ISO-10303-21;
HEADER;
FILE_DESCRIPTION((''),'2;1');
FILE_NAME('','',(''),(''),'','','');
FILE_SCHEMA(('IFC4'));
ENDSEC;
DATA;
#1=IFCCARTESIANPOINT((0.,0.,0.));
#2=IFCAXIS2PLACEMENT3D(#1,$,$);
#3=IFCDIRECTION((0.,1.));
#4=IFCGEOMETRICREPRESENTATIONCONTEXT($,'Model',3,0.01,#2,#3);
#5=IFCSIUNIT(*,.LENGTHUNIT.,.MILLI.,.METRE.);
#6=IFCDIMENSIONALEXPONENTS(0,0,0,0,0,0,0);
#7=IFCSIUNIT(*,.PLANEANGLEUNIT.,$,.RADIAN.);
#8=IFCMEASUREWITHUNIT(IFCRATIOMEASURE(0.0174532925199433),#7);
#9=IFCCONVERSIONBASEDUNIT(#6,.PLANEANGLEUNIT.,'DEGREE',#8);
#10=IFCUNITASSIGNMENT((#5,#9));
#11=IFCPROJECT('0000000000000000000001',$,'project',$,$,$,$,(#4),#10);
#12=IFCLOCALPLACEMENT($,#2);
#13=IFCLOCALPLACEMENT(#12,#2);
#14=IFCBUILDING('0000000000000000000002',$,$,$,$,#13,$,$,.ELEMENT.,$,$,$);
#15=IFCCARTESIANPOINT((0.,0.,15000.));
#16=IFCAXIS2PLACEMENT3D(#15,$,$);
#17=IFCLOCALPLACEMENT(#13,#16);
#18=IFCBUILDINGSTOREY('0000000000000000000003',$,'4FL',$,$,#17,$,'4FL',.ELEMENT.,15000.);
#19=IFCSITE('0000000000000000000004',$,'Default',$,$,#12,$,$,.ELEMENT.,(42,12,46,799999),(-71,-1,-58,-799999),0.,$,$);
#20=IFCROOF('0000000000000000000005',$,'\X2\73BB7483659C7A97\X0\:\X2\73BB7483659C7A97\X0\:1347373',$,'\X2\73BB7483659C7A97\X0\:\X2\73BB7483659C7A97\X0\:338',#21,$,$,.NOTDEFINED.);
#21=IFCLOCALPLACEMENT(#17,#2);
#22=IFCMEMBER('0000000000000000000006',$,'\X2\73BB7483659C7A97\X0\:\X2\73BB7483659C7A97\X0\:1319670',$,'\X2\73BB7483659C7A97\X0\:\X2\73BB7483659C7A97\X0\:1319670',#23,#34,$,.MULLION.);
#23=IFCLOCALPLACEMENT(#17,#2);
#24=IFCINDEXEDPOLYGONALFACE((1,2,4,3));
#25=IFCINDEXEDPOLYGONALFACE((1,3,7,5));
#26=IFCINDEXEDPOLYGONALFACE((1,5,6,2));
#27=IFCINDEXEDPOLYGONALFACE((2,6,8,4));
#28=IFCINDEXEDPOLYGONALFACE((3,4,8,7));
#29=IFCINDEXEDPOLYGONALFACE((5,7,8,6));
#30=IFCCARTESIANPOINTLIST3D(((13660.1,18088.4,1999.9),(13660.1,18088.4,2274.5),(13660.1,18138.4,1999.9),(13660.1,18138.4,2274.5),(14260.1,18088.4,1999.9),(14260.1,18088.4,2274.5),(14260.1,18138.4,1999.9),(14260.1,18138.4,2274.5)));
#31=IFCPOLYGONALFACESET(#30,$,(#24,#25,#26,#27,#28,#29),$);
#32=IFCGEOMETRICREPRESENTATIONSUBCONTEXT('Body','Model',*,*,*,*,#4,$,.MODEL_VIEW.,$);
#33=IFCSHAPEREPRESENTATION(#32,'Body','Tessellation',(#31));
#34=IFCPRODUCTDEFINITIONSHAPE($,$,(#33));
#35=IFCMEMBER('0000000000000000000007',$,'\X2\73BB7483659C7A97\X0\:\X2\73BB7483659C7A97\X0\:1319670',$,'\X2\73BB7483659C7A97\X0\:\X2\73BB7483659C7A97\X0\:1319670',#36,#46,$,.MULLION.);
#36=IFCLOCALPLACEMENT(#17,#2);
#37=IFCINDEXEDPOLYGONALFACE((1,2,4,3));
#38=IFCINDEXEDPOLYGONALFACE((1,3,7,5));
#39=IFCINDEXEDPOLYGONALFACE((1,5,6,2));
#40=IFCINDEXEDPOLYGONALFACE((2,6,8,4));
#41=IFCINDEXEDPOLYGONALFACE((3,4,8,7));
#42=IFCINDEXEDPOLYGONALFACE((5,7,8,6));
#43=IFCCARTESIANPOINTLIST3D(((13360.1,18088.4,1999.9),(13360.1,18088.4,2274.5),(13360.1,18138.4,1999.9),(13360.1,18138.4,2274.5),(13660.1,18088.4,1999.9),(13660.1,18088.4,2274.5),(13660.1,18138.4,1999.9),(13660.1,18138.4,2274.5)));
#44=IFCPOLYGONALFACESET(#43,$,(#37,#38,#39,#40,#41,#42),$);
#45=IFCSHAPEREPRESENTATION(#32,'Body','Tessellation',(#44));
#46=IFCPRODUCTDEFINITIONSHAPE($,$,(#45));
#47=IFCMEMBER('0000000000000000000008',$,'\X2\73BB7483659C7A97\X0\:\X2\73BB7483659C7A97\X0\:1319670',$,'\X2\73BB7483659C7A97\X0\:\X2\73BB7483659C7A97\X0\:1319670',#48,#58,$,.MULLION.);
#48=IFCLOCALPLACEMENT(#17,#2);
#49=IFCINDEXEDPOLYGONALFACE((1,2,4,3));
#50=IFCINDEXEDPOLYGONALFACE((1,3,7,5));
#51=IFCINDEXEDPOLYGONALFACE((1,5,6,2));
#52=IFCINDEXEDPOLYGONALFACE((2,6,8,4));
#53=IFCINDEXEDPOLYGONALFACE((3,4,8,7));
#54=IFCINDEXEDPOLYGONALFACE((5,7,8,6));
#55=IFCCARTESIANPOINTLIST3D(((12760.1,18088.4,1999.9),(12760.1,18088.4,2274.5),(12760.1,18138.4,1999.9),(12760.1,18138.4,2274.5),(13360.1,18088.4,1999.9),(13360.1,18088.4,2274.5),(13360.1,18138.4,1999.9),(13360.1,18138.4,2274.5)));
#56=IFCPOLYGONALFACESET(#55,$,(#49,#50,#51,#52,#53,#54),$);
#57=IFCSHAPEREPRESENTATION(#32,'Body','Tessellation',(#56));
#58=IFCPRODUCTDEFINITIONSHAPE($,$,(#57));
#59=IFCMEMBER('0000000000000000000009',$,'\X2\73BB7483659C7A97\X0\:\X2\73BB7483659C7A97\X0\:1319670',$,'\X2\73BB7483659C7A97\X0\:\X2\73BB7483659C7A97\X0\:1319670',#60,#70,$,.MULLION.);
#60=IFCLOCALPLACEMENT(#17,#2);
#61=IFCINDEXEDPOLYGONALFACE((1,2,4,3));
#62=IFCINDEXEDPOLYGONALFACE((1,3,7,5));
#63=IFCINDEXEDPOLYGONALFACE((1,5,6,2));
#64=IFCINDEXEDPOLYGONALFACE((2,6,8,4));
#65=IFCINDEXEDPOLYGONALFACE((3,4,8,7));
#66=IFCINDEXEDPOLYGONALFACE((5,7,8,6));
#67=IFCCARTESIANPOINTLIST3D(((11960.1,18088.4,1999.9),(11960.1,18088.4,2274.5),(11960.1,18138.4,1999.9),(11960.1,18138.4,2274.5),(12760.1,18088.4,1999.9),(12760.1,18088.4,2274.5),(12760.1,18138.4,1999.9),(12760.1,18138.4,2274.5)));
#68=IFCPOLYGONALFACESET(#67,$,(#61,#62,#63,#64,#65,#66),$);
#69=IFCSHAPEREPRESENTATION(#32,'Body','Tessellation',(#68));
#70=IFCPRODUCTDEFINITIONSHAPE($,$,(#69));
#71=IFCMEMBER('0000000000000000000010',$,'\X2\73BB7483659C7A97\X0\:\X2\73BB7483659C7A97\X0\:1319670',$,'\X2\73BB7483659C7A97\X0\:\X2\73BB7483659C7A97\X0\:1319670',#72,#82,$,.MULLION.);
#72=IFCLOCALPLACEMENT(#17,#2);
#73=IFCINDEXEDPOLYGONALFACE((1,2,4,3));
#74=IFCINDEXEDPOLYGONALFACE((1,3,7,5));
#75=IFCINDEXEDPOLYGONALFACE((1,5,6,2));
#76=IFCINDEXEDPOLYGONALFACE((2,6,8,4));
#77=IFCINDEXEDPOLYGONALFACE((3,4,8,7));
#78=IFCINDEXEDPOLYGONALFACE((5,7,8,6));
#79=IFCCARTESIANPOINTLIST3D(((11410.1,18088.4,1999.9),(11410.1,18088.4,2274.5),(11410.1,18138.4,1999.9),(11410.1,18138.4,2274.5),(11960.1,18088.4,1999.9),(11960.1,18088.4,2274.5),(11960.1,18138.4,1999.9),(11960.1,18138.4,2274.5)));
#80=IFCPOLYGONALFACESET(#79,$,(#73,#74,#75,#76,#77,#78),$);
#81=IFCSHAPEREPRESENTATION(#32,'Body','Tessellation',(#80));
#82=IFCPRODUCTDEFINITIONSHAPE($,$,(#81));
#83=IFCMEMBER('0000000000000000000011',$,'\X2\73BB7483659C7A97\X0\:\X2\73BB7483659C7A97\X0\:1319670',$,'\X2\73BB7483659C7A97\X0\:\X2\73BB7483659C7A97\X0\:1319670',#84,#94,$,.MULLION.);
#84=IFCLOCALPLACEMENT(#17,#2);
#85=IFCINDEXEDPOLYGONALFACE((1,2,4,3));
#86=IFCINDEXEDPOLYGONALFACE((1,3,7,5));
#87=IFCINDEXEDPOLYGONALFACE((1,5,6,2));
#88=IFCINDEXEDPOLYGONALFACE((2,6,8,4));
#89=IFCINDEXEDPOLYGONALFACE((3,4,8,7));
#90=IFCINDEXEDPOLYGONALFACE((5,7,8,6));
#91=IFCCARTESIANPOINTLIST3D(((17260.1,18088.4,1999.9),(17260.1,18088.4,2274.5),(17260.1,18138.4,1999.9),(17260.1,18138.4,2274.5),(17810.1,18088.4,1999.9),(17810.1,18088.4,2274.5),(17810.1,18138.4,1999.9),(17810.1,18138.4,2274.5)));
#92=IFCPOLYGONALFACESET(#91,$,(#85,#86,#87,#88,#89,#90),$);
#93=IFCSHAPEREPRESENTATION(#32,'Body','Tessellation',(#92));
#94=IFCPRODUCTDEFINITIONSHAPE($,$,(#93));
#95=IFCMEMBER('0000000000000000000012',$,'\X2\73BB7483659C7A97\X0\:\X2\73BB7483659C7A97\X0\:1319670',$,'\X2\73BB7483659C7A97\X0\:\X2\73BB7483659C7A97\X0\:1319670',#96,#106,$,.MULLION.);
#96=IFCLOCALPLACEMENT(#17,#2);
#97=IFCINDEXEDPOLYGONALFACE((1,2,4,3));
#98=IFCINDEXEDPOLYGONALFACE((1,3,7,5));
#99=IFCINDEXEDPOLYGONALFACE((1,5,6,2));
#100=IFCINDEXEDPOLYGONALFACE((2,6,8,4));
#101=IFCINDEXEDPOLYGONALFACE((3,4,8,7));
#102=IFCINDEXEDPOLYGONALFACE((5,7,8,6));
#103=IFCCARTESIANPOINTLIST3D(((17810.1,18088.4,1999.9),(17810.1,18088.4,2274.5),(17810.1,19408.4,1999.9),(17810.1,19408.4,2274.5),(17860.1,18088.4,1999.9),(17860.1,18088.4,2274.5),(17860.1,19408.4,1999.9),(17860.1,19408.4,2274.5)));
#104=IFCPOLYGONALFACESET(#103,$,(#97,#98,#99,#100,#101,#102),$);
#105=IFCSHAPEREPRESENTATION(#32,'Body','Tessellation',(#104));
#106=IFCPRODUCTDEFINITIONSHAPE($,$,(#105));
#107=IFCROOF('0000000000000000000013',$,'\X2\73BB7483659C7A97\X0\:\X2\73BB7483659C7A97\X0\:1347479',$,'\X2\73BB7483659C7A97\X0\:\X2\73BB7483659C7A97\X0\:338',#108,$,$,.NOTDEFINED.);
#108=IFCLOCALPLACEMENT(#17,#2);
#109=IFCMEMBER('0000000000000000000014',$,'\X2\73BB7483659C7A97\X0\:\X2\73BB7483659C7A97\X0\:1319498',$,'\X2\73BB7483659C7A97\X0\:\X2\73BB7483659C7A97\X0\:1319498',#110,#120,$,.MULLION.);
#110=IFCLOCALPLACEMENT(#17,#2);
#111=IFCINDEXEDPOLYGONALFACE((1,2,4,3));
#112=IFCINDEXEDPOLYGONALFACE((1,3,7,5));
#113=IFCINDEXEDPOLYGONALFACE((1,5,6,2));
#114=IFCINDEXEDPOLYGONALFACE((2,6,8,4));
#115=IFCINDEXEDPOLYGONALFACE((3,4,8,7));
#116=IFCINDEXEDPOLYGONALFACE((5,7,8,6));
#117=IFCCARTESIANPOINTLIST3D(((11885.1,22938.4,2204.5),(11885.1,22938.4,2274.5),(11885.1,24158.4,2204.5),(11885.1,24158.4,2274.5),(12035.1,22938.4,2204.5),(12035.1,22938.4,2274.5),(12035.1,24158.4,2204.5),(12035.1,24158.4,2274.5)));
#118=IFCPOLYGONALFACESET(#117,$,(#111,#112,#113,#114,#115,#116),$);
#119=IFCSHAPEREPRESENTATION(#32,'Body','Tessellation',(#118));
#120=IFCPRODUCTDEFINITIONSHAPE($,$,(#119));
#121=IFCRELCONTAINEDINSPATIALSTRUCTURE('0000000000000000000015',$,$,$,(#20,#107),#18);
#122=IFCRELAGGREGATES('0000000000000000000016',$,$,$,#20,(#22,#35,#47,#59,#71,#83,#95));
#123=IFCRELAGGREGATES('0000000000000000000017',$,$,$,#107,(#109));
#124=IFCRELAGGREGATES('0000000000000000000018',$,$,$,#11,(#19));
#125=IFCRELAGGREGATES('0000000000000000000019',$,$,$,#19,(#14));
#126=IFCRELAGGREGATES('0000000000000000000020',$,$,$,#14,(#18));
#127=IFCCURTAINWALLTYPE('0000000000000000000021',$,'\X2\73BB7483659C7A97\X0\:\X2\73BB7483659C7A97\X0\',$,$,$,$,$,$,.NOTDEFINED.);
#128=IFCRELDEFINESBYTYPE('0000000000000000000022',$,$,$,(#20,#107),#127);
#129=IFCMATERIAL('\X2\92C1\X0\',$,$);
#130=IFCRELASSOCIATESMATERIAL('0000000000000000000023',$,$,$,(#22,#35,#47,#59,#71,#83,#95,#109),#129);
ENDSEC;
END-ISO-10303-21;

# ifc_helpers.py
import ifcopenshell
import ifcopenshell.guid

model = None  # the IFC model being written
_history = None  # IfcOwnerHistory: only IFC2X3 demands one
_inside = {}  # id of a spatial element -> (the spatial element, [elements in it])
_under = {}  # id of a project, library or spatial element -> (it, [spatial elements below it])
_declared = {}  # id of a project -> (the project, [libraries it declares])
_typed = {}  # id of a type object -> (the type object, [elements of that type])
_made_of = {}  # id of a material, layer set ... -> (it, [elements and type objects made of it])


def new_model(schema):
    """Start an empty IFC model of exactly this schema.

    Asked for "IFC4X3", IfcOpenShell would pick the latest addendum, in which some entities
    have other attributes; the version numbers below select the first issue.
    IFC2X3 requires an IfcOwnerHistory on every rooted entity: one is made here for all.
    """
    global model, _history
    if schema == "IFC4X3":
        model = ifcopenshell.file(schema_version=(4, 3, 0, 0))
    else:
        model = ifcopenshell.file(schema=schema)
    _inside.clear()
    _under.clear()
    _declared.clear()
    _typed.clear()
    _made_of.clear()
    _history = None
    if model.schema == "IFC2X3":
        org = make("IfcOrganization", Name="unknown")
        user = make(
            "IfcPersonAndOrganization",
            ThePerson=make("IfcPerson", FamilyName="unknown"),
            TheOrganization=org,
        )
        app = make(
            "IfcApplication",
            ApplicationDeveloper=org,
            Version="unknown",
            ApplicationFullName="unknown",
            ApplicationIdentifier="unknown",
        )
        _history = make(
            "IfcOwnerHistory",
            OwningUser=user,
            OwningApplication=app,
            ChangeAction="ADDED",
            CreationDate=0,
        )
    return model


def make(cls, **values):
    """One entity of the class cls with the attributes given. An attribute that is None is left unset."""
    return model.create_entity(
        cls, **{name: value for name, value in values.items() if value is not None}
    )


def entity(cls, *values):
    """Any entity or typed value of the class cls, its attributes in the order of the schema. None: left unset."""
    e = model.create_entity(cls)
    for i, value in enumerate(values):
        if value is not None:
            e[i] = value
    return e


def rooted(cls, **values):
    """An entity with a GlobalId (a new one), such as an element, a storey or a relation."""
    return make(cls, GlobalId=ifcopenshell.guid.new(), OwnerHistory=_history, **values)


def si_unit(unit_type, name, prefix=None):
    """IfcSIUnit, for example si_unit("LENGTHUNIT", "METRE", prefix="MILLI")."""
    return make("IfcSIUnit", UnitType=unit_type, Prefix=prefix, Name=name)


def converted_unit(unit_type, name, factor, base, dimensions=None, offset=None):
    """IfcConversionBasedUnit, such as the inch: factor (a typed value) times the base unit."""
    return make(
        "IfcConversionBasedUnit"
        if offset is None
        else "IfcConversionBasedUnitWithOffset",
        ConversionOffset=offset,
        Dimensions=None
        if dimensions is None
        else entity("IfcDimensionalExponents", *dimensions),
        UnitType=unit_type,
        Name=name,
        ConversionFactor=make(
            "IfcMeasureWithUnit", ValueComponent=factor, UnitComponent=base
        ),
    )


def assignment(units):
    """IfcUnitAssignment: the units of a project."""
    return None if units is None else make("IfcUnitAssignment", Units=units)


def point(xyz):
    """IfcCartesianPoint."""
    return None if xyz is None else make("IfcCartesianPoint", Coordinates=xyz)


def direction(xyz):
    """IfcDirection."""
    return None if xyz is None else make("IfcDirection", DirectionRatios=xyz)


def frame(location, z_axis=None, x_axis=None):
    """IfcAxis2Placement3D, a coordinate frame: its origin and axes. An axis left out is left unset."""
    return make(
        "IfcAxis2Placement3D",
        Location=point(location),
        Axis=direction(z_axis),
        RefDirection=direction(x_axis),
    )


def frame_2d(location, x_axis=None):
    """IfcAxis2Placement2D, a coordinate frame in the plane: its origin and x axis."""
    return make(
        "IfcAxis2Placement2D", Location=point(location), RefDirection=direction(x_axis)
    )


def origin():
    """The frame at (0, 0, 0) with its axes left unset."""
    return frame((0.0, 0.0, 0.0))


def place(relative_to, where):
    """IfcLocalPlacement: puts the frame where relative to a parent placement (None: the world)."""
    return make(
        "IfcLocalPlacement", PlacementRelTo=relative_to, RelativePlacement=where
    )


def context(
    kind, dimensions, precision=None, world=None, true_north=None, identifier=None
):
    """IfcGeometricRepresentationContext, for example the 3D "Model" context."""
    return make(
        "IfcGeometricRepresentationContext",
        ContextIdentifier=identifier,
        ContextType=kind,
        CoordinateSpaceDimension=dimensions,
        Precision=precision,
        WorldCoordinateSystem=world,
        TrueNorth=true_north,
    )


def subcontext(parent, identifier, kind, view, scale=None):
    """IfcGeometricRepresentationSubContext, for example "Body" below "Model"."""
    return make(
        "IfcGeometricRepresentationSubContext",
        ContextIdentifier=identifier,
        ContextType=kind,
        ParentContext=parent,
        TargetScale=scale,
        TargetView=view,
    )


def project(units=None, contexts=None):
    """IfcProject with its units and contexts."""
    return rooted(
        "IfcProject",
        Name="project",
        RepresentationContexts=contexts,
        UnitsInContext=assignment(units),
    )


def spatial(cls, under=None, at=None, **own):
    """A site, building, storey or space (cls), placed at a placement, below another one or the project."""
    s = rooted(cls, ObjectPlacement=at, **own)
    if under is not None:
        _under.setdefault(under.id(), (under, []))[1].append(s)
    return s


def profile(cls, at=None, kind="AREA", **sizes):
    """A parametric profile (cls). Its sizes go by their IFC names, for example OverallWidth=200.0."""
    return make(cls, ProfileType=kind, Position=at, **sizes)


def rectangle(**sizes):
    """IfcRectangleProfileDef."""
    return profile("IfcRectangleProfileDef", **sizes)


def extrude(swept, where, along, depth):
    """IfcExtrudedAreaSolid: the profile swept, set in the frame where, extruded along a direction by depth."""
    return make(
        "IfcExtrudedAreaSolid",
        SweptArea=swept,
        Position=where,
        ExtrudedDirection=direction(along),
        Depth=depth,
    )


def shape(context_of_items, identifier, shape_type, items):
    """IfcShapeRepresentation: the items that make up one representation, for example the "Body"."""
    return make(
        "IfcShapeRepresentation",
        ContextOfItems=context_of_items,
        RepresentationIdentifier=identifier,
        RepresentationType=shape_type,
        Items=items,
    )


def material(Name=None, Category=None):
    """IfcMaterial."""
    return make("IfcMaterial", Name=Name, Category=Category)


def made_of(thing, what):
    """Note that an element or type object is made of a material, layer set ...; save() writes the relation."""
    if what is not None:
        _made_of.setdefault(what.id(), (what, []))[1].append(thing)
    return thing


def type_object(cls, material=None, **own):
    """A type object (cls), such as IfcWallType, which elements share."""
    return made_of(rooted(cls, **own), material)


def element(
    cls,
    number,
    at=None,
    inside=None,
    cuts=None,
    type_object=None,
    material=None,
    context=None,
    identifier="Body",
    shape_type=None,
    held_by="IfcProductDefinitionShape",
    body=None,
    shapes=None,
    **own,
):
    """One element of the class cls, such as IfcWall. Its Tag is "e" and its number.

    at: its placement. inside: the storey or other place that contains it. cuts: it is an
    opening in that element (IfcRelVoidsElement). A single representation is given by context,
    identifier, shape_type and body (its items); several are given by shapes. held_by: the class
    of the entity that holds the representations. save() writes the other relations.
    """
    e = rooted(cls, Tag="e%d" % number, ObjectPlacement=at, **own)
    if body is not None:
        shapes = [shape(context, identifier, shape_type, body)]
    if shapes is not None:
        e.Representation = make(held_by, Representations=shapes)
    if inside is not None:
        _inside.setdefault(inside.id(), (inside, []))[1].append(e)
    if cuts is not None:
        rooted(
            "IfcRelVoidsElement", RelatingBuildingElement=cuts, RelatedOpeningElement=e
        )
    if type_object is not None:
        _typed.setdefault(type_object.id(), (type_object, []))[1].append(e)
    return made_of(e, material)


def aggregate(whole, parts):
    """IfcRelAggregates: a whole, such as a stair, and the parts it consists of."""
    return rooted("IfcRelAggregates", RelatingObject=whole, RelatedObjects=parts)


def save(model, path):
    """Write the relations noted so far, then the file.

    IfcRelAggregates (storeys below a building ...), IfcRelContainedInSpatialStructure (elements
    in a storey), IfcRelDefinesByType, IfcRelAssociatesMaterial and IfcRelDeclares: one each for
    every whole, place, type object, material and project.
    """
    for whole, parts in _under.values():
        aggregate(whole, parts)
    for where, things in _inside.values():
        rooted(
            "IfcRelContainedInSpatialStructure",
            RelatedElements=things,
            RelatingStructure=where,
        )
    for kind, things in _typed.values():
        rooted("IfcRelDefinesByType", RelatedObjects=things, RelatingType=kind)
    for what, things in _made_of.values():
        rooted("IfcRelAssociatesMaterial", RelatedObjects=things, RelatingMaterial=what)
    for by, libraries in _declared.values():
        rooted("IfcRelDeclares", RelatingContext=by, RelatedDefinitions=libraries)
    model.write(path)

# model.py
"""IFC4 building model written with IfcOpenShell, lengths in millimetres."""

from ifc_helpers import new_model, entity, si_unit, converted_unit, direction, frame, frame_2d, origin, place, context, subcontext, project, spatial, rectangle, extrude, material, type_object, element, aggregate, save


model = new_model("IFC4")

# Units and contexts
model_context = context("Model", 3, precision=0.01, world=origin(), true_north=direction((0.0, 1.0)))
body_context = subcontext(model_context, "Body", "Model", "MODEL_VIEW")
ifc_project = project(units=[si_unit("LENGTHUNIT", "METRE", prefix="MILLI"), converted_unit("PLANEANGLEUNIT", "DEGREE", entity("IfcRatioMeasure", 0.0174532925199433), si_unit("PLANEANGLEUNIT", "RADIAN"), dimensions=[0, 0, 0, 0, 0, 0, 0])], contexts=[model_context])

# Site, building, storey
site_placement = place(None, origin())
site = spatial("IfcSite", under=ifc_project, at=site_placement, Name="Default", CompositionType="ELEMENT", RefLatitude=(42, 12, 46, 799999), RefLongitude=(-71, -1, -58, -799999), RefElevation=0.0)
building_placement = place(site_placement, origin())
building = spatial("IfcBuilding", under=site, at=building_placement, CompositionType="ELEMENT")
storey_placement = place(building_placement, frame((0.0, 0.0, 15000.0)))
storey = spatial("IfcBuildingStorey", under=building, at=storey_placement, Name="4FL", LongName="4FL", CompositionType="ELEMENT", Elevation=15000.0)

# Roof, members
curtain_wall_type = type_object("IfcCurtainWallType", Name="玻璃斜窗:玻璃斜窗", PredefinedType="NOTDEFINED")
roof_1_placement = place(storey_placement, frame((0.0, 0.0, -15000.0)))
roof_1 = element("IfcRoof", 1, at=roof_1_placement, inside=storey, type_object=curtain_wall_type, Name="玻璃斜窗:玻璃斜窗:1347373", ObjectType="玻璃斜窗:玻璃斜窗:338", PredefinedType="NOTDEFINED")
ifc_material = material(Name="鋁")
member_1_placement = place(roof_1_placement, frame((0.0, 0.0, 15000.0)))
member_1 = element("IfcMember", 2, at=member_1_placement, material=ifc_material, Name="玻璃斜窗:玻璃斜窗:1319670", ObjectType="玻璃斜窗:玻璃斜窗:1319670", PredefinedType="MULLION", context=body_context, shape_type="SweptSolid", body=[
    extrude(rectangle(XDim=274.5, YDim=50.0, at=frame_2d((0.0, 0.0), x_axis=(1.0, 0.0))), frame((14260.1, 18113.4, 2137.2), z_axis=(-1.0, 0.0, 0.0), x_axis=(0.0, 0.0, -1.0)), (0.0, 0.0, 1.0), 600.0),
])
member_2_placement = place(roof_1_placement, frame((0.0, 0.0, 15000.0)))
member_2 = element("IfcMember", 3, at=member_2_placement, material=ifc_material, Name="玻璃斜窗:玻璃斜窗:1319670", ObjectType="玻璃斜窗:玻璃斜窗:1319670", PredefinedType="MULLION", context=body_context, shape_type="SweptSolid", body=[
    extrude(rectangle(XDim=274.5, YDim=50.0, at=frame_2d((0.0, 0.0), x_axis=(1.0, 0.0))), frame((13660.1, 18113.4, 2137.2), z_axis=(-1.0, 0.0, 0.0), x_axis=(0.0, 0.0, -1.0)), (0.0, 0.0, 1.0), 300.0),
])
member_3_placement = place(roof_1_placement, frame((0.0, 0.0, 15000.0)))
member_3 = element("IfcMember", 4, at=member_3_placement, material=ifc_material, Name="玻璃斜窗:玻璃斜窗:1319670", ObjectType="玻璃斜窗:玻璃斜窗:1319670", PredefinedType="MULLION", context=body_context, shape_type="SweptSolid", body=[
    extrude(rectangle(XDim=274.5, YDim=50.0, at=frame_2d((0.0, 0.0), x_axis=(1.0, 0.0))), frame((13360.1, 18113.4, 2137.2), z_axis=(-1.0, 0.0, 0.0), x_axis=(0.0, 0.0, -1.0)), (0.0, 0.0, 1.0), 600.0),
])
member_4_placement = place(roof_1_placement, frame((0.0, 0.0, 15000.0)))
member_4 = element("IfcMember", 5, at=member_4_placement, material=ifc_material, Name="玻璃斜窗:玻璃斜窗:1319670", ObjectType="玻璃斜窗:玻璃斜窗:1319670", PredefinedType="MULLION", context=body_context, shape_type="SweptSolid", body=[
    extrude(rectangle(XDim=274.5, YDim=50.0, at=frame_2d((0.0, 0.0), x_axis=(1.0, 0.0))), frame((12760.1, 18113.4, 2137.2), z_axis=(-1.0, 0.0, 0.0), x_axis=(0.0, 0.0, -1.0)), (0.0, 0.0, 1.0), 800.0),
])
member_5_placement = place(roof_1_placement, frame((0.0, 0.0, 15000.0)))
member_5 = element("IfcMember", 6, at=member_5_placement, material=ifc_material, Name="玻璃斜窗:玻璃斜窗:1319670", ObjectType="玻璃斜窗:玻璃斜窗:1319670", PredefinedType="MULLION", context=body_context, shape_type="SweptSolid", body=[
    extrude(rectangle(XDim=274.5, YDim=50.0, at=frame_2d((0.0, 0.0), x_axis=(1.0, 0.0))), frame((11960.1, 18113.4, 2137.2), z_axis=(-1.0, 0.0, 0.0), x_axis=(0.0, 0.0, -1.0)), (0.0, 0.0, 1.0), 550.0),
])
member_6_placement = place(roof_1_placement, frame((0.0, 0.0, 15000.0)))
member_6 = element("IfcMember", 7, at=member_6_placement, material=ifc_material, Name="玻璃斜窗:玻璃斜窗:1319670", ObjectType="玻璃斜窗:玻璃斜窗:1319670", PredefinedType="MULLION", context=body_context, shape_type="SweptSolid", body=[
    extrude(rectangle(XDim=274.5, YDim=50.0, at=frame_2d((0.0, 0.0), x_axis=(1.0, 0.0))), frame((17810.1, 18113.4, 2137.2), z_axis=(-1.0, 0.0, 0.0), x_axis=(0.0, 0.0, -1.0)), (0.0, 0.0, 1.0), 550.0),
])
member_7_placement = place(roof_1_placement, frame((0.0, 0.0, 15000.0)))
member_7 = element("IfcMember", 8, at=member_7_placement, material=ifc_material, Name="玻璃斜窗:玻璃斜窗:1319670", ObjectType="玻璃斜窗:玻璃斜窗:1319670", PredefinedType="MULLION", context=body_context, shape_type="SweptSolid", body=[
    extrude(rectangle(XDim=274.5, YDim=50.0, at=frame_2d((0.0, 0.0), x_axis=(1.0, 0.0))), frame((17835.1, 19408.4, 2137.2), z_axis=(0.0, -1.0, 0.0), x_axis=(0.0, 0.0, -1.0)), (0.0, 0.0, 1.0), 1320.0),
])
aggregate(roof_1, [member_1, member_2, member_3, member_4, member_5, member_6, member_7])

# Roof, member
roof_2_placement = place(storey_placement, frame((0.0, 0.0, -15000.0)))
roof_2 = element("IfcRoof", 9, at=roof_2_placement, inside=storey, type_object=curtain_wall_type, Name="玻璃斜窗:玻璃斜窗:1347479", ObjectType="玻璃斜窗:玻璃斜窗:338", PredefinedType="NOTDEFINED")
member_8_placement = place(roof_2_placement, frame((0.0, 0.0, 15000.0)))
member_8 = element("IfcMember", 10, at=member_8_placement, material=ifc_material, Name="玻璃斜窗:玻璃斜窗:1319498", ObjectType="玻璃斜窗:玻璃斜窗:1319498", PredefinedType="MULLION", context=body_context, shape_type="SweptSolid", body=[
    extrude(rectangle(XDim=70.0, YDim=150.0, at=frame_2d((0.0, 0.0), x_axis=(1.0, 0.0))), frame((11960.1, 22938.4, 2239.5), z_axis=(0.0, 1.0, 0.0), x_axis=(0.0, 0.0, -1.0)), (0.0, 0.0, 1.0), 1220.0),
])
aggregate(roof_2, [member_8])

save(model, "model.ifc")
